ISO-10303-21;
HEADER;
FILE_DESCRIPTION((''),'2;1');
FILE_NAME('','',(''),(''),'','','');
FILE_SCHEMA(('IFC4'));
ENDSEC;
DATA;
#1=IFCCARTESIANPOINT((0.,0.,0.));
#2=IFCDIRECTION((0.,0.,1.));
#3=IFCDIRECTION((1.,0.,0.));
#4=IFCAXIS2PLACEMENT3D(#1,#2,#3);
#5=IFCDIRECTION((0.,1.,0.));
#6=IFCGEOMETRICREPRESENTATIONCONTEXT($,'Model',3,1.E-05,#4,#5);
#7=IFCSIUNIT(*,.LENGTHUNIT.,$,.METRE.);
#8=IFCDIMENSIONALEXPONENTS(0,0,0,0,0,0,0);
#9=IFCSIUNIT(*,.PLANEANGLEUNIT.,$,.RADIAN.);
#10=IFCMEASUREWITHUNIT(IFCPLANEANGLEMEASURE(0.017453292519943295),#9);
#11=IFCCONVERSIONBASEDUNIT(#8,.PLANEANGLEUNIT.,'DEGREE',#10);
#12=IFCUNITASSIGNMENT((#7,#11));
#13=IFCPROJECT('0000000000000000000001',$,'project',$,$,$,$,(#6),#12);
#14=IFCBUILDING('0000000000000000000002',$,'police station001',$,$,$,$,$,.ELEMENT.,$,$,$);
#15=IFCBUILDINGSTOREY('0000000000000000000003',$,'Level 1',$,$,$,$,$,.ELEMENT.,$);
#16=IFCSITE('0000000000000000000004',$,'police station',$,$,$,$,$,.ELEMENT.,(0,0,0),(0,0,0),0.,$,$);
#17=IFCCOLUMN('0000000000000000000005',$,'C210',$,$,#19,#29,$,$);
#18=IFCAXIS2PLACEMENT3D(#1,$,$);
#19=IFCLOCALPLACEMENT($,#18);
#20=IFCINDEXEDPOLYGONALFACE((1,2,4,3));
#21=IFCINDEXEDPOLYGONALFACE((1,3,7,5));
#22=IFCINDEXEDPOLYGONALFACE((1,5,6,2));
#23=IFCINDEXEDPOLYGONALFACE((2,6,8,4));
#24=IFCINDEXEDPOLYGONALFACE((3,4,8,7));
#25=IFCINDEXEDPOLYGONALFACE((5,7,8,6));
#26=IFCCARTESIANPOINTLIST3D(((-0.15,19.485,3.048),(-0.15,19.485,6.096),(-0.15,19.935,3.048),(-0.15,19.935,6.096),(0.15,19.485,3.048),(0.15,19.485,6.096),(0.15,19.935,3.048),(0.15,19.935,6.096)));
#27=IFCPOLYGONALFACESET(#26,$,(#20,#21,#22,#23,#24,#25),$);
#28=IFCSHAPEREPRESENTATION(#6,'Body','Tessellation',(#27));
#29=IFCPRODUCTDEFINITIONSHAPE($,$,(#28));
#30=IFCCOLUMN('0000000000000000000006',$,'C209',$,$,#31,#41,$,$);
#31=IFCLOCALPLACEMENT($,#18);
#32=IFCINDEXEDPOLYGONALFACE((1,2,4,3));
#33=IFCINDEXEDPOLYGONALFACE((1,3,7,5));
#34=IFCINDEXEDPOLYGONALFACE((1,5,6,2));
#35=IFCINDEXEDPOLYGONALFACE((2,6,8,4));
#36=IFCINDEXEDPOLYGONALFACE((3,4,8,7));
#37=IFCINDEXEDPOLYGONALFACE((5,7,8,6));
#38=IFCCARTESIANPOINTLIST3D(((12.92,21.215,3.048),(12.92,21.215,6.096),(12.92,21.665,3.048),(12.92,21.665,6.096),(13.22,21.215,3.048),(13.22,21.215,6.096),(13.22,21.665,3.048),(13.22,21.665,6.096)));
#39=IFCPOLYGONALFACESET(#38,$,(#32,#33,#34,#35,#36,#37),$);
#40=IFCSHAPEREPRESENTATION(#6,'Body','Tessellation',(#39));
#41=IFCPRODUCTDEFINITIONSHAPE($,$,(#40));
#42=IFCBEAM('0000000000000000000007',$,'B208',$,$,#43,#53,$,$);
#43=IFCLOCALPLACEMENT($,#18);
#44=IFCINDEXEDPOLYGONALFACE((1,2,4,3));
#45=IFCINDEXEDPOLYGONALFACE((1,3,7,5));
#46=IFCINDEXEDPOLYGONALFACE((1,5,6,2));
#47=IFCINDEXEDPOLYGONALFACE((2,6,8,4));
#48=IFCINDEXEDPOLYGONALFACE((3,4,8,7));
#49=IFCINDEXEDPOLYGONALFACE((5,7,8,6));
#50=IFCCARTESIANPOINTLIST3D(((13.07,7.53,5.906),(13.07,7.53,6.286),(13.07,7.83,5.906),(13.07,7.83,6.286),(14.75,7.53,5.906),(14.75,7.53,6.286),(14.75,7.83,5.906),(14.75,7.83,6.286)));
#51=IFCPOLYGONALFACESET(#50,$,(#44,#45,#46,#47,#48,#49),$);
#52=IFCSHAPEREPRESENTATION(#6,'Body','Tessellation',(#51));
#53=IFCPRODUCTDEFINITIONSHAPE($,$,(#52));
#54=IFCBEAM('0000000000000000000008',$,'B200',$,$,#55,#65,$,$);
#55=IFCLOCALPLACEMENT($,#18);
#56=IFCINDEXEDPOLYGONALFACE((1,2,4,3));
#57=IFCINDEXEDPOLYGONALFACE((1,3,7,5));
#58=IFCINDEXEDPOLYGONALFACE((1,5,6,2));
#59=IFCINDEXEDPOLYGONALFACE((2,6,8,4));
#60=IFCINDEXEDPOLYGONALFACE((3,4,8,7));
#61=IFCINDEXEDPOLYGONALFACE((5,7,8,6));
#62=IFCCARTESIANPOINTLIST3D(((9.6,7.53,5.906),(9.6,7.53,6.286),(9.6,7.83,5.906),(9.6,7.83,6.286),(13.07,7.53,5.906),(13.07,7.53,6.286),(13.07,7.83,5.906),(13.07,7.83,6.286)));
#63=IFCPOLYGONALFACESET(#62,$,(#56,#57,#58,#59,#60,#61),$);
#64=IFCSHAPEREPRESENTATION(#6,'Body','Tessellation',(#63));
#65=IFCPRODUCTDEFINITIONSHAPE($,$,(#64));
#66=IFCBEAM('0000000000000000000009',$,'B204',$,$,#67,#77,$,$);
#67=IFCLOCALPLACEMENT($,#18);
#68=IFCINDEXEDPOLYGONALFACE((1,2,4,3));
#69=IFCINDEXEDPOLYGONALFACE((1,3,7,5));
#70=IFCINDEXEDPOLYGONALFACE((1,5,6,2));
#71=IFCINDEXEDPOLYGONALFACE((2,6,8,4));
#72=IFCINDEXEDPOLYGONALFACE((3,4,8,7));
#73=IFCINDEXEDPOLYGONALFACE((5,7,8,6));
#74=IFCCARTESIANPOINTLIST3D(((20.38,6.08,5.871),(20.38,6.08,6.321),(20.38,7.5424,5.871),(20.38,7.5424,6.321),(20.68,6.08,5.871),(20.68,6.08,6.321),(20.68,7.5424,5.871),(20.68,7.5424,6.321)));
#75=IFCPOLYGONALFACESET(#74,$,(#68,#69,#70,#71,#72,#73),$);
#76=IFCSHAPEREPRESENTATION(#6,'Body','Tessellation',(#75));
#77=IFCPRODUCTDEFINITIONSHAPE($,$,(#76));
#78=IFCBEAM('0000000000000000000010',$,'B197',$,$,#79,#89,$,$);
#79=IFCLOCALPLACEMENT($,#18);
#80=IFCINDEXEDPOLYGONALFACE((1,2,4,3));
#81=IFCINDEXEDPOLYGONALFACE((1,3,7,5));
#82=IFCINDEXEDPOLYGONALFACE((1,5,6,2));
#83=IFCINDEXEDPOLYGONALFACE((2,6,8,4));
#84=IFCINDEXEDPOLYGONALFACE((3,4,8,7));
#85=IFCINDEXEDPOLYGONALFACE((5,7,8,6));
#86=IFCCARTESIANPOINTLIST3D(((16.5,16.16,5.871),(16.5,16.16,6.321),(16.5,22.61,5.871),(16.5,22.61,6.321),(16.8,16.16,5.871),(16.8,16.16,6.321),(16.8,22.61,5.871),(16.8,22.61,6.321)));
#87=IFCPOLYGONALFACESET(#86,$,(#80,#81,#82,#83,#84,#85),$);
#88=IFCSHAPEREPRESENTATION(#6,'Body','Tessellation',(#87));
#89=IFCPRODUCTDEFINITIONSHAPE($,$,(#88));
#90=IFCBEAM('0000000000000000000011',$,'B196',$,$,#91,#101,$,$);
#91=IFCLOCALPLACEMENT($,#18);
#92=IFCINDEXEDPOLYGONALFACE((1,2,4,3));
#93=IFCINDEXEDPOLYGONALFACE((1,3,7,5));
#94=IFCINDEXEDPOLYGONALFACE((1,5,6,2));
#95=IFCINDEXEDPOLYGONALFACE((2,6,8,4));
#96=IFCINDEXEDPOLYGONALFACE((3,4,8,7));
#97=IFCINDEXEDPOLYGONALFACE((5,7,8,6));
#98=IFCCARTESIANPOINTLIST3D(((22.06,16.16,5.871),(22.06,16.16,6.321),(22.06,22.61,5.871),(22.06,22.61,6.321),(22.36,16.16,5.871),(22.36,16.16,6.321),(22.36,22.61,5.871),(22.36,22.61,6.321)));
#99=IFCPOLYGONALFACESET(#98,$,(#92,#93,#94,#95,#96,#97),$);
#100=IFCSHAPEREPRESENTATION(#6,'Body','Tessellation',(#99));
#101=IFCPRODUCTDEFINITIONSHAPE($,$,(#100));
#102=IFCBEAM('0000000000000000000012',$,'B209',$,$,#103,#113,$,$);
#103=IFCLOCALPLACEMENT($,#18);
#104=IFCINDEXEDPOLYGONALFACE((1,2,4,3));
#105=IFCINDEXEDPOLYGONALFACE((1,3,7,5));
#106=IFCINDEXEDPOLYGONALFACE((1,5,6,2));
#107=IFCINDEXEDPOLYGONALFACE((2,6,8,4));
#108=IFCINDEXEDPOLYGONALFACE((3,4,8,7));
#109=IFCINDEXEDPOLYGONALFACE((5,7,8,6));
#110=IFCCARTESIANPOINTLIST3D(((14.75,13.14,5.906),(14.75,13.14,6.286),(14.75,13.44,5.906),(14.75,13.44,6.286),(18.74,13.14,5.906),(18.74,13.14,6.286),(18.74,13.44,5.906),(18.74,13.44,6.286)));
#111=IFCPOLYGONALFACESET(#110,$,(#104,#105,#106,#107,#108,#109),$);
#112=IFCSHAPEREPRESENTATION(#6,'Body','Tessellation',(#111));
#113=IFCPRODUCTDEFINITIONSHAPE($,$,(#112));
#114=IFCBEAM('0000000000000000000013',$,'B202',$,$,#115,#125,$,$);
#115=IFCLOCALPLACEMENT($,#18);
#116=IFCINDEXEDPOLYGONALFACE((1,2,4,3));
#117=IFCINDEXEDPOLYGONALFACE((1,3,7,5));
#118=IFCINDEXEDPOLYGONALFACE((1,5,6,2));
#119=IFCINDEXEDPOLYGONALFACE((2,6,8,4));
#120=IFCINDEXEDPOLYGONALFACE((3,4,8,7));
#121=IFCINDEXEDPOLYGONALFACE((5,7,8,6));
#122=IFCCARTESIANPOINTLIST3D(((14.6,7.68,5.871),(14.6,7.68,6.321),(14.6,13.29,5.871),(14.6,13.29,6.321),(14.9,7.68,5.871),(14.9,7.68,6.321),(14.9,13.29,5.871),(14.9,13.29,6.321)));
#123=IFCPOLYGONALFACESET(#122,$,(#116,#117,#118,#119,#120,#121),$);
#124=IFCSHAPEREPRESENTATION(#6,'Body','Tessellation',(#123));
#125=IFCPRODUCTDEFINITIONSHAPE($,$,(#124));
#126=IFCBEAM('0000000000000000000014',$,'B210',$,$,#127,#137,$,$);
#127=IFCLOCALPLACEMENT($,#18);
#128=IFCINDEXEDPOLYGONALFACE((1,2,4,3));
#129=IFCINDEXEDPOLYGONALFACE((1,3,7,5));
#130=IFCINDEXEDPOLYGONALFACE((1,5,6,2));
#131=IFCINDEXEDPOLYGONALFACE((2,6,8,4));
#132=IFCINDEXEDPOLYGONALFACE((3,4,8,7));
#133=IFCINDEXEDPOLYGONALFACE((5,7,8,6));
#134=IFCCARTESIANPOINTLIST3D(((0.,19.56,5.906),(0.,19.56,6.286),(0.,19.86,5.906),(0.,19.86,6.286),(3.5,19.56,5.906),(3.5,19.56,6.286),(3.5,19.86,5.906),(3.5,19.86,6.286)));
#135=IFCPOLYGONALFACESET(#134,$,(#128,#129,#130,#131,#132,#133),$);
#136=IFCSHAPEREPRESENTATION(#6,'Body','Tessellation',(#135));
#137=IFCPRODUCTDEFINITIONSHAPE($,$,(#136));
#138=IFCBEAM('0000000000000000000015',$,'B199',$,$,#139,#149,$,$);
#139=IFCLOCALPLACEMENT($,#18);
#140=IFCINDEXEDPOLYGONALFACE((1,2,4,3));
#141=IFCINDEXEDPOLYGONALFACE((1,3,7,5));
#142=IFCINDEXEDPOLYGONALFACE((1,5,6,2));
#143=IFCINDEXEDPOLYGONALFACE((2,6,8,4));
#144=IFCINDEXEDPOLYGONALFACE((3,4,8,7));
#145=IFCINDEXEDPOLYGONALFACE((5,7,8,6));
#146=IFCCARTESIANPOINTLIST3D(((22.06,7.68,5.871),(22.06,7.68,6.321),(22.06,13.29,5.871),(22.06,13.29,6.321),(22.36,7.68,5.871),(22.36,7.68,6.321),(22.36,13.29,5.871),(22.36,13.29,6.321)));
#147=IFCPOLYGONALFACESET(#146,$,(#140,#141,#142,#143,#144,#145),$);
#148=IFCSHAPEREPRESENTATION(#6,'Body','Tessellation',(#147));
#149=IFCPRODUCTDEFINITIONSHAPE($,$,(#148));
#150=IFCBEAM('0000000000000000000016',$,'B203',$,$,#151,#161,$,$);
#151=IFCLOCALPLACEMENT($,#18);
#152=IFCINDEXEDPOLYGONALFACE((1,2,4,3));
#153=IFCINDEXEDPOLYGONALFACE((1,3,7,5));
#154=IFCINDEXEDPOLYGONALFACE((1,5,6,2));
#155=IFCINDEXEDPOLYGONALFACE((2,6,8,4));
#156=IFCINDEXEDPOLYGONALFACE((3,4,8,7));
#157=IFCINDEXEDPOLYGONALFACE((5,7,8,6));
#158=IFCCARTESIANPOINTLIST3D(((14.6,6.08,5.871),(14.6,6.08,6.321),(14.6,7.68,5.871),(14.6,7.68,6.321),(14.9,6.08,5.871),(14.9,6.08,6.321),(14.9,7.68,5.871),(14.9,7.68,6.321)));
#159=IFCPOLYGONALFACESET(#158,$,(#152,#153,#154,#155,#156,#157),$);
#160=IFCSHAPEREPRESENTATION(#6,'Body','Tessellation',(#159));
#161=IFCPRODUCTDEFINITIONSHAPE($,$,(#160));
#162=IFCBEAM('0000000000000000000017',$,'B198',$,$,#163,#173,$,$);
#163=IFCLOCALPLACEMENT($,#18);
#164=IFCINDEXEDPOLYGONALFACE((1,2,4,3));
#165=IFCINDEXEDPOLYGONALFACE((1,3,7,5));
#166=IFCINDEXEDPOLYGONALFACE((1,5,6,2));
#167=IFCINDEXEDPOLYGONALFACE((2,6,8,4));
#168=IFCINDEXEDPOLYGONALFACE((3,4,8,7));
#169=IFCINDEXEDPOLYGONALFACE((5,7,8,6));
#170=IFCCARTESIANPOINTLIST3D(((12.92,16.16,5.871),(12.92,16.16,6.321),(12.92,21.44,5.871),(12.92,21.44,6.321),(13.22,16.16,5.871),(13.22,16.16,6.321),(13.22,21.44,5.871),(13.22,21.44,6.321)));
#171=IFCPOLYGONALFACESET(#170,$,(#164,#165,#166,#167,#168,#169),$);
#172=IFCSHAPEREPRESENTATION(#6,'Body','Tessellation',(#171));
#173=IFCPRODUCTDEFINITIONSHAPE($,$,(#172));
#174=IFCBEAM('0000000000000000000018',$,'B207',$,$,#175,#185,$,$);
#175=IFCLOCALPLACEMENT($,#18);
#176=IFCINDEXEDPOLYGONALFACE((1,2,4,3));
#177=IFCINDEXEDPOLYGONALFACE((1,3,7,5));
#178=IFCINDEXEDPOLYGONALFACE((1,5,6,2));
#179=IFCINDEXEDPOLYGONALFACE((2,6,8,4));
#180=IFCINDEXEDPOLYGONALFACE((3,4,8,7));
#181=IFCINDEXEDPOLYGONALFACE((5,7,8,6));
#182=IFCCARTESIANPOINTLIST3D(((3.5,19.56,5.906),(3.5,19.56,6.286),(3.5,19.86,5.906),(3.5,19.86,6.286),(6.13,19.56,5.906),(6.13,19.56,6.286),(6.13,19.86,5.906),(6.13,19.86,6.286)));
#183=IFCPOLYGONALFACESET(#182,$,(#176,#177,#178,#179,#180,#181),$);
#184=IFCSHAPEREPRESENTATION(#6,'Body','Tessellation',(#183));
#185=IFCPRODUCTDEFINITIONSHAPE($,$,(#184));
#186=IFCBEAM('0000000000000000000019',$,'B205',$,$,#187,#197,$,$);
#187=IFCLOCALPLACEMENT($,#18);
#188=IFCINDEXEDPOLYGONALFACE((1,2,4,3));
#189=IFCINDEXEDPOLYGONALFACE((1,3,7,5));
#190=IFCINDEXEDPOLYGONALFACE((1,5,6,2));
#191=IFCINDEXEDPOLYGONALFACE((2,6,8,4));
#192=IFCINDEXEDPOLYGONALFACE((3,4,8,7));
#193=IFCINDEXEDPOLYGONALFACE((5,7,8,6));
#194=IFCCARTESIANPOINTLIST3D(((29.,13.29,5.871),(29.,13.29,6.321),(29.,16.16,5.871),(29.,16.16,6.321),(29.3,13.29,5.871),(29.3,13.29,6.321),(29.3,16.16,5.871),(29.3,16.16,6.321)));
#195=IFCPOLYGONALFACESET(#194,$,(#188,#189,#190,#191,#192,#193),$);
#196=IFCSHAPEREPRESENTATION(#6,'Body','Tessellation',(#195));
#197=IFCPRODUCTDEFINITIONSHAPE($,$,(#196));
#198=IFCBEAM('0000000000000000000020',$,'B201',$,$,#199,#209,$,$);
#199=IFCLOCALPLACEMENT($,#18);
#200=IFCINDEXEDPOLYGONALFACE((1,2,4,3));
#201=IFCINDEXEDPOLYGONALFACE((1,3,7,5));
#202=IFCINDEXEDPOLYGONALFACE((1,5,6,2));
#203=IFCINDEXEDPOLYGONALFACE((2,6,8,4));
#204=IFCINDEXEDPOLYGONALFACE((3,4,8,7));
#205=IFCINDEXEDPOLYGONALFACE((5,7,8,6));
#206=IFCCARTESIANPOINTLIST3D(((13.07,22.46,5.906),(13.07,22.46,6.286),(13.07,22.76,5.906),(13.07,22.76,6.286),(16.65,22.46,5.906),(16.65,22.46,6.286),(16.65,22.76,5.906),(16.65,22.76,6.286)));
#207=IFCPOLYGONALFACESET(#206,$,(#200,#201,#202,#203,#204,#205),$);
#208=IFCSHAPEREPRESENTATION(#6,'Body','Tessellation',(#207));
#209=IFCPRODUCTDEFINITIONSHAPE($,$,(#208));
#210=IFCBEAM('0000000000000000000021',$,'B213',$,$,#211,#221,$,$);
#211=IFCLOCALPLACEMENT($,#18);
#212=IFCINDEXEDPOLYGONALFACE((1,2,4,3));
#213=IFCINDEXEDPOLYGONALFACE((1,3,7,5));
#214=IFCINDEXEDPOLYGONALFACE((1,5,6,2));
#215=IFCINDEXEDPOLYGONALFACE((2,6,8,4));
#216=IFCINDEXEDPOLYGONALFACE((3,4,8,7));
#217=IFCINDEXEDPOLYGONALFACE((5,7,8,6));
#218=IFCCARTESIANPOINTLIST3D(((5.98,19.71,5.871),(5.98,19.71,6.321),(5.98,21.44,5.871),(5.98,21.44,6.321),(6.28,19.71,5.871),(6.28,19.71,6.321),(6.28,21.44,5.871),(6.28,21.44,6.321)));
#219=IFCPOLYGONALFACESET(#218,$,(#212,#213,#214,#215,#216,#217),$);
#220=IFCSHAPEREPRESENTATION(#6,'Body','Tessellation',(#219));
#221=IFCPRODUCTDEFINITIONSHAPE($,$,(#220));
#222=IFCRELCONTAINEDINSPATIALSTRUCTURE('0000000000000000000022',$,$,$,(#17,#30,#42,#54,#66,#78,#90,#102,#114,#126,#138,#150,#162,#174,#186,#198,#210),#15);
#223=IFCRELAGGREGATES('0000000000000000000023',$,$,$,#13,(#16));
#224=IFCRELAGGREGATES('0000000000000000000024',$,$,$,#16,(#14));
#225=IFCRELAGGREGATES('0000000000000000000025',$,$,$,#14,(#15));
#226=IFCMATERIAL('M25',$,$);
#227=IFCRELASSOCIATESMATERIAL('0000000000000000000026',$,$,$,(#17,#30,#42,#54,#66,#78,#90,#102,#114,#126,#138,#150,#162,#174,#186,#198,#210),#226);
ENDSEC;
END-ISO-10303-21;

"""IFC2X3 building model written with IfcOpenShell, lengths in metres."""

from ifc_helpers import new_model, entity, si_unit, converted_unit, direction, frame, frame_2d, origin_with_axes, place, context, project, spatial, rectangle, extrude, material, element, save


model = new_model("IFC2X3")

# Units and contexts
model_context = context("Model", 3, precision=1e-05, world=origin_with_axes(), true_north=direction((0.0, 1.0, 0.0)))
ifc_project = project(units=[si_unit("LENGTHUNIT", "METRE"), converted_unit("PLANEANGLEUNIT", "DEGREE", entity("IfcPlaneAngleMeasure", 0.017453292519943295), si_unit("PLANEANGLEUNIT", "RADIAN"), dimensions=[0, 0, 0, 0, 0, 0, 0])], contexts=[model_context])

# Site, building, storey
site = spatial("IfcSite", under=ifc_project, Name="police station", CompositionType="ELEMENT", RefLatitude=(0, 0, 0), RefLongitude=(0, 0, 0), RefElevation=0.0)
building = spatial("IfcBuilding", under=site, Name="police station001", CompositionType="ELEMENT")
storey = spatial("IfcBuildingStorey", under=building, Name="Level 1", CompositionType="ELEMENT")

# Columns
ifc_material = material(Name="M25")
placement = place(None, origin_with_axes())
element("IfcColumn", 1, at=placement, inside=storey, material=ifc_material, Name="C210", context=model_context, shape_type="SweptSolid", body=[
    extrude(rectangle(XDim=0.3, YDim=0.45, at=frame_2d((0.0, 0.0), x_axis=(1.0, 0.0, 0.0))), frame((0.0, 19.71, 3.048), z_axis=(0.0, 0.0, 1.0), x_axis=(1.0, 0.0, 0.0)), (0.0, 0.0, 1.0), 3.048),
])
element("IfcColumn", 2, at=placement, inside=storey, material=ifc_material, Name="C209", context=model_context, shape_type="SweptSolid", body=[
    extrude(rectangle(XDim=0.3, YDim=0.45, at=frame_2d((0.0, 0.0), x_axis=(1.0, 0.0, 0.0))), frame((13.07, 21.44, 3.048), z_axis=(0.0, 0.0, 1.0), x_axis=(1.0, 0.0, 0.0)), (0.0, 0.0, 1.0), 3.048),
])

# Beams
element("IfcBeam", 3, at=placement, inside=storey, material=ifc_material, Name="B208", context=model_context, shape_type="SweptSolid", body=[
    extrude(rectangle(XDim=0.3, YDim=0.38, at=frame_2d((0.0, 0.0), x_axis=(0.0, 1.0, 0.0))), frame((13.07, 7.68, 6.096), z_axis=(1.0, 0.0, 0.0), x_axis=(0.0, 0.0, -1.0)), (0.0, 0.0, 1.0), 1.68),
])
element("IfcBeam", 4, at=placement, inside=storey, material=ifc_material, Name="B200", context=model_context, shape_type="SweptSolid", body=[
    extrude(rectangle(XDim=0.3, YDim=0.38, at=frame_2d((0.0, 0.0), x_axis=(0.0, 1.0, 0.0))), frame((9.6, 7.68, 6.096), z_axis=(1.0, 0.0, 0.0), x_axis=(0.0, 0.0, -1.0)), (0.0, 0.0, 1.0), 3.47),
])
element("IfcBeam", 5, at=placement, inside=storey, material=ifc_material, Name="B204", context=model_context, shape_type="SweptSolid", body=[
    extrude(rectangle(XDim=0.3, YDim=0.45, at=frame_2d((0.0, 0.0), x_axis=(0.0, 1.0, 0.0))), frame((20.53, 6.08, 6.096), z_axis=(0.0, 1.0, 0.0), x_axis=(0.0, 0.0, -1.0)), (0.0, 0.0, 1.0), 1.4624),
])
element("IfcBeam", 6, at=placement, inside=storey, material=ifc_material, Name="B197", context=model_context, shape_type="SweptSolid", body=[
    extrude(rectangle(XDim=0.3, YDim=0.45, at=frame_2d((0.0, 0.0), x_axis=(0.0, 1.0, 0.0))), frame((16.65, 16.16, 6.096), z_axis=(0.0, 1.0, 0.0), x_axis=(0.0, 0.0, -1.0)), (0.0, 0.0, 1.0), 6.45),
])
element("IfcBeam", 7, at=placement, inside=storey, material=ifc_material, Name="B196", context=model_context, shape_type="SweptSolid", body=[
    extrude(rectangle(XDim=0.3, YDim=0.45, at=frame_2d((0.0, 0.0), x_axis=(0.0, 1.0, 0.0))), frame((22.21, 16.16, 6.096), z_axis=(0.0, 1.0, 0.0), x_axis=(0.0, 0.0, -1.0)), (0.0, 0.0, 1.0), 6.45),
])
element("IfcBeam", 8, at=placement, inside=storey, material=ifc_material, Name="B209", context=model_context, shape_type="SweptSolid", body=[
    extrude(rectangle(XDim=0.3, YDim=0.38, at=frame_2d((0.0, 0.0), x_axis=(0.0, 1.0, 0.0))), frame((14.75, 13.29, 6.096), z_axis=(1.0, 0.0, 0.0), x_axis=(0.0, 0.0, -1.0)), (0.0, 0.0, 1.0), 3.99),
])
element("IfcBeam", 9, at=placement, inside=storey, material=ifc_material, Name="B202", context=model_context, shape_type="SweptSolid", body=[
    extrude(rectangle(XDim=0.3, YDim=0.45, at=frame_2d((0.0, 0.0), x_axis=(0.0, 1.0, 0.0))), frame((14.75, 7.68, 6.096), z_axis=(0.0, 1.0, 0.0), x_axis=(0.0, 0.0, -1.0)), (0.0, 0.0, 1.0), 5.61),
])
element("IfcBeam", 10, at=placement, inside=storey, material=ifc_material, Name="B210", context=model_context, shape_type="SweptSolid", body=[
    extrude(rectangle(XDim=0.3, YDim=0.38, at=frame_2d((0.0, 0.0), x_axis=(0.0, 1.0, 0.0))), frame((0.0, 19.71, 6.096), z_axis=(1.0, 0.0, 0.0), x_axis=(0.0, 0.0, -1.0)), (0.0, 0.0, 1.0), 3.5),
])
element("IfcBeam", 11, at=placement, inside=storey, material=ifc_material, Name="B199", context=model_context, shape_type="SweptSolid", body=[
    extrude(rectangle(XDim=0.3, YDim=0.45, at=frame_2d((0.0, 0.0), x_axis=(0.0, 1.0, 0.0))), frame((22.21, 7.68, 6.096), z_axis=(0.0, 1.0, 0.0), x_axis=(0.0, 0.0, -1.0)), (0.0, 0.0, 1.0), 5.61),
])
element("IfcBeam", 12, at=placement, inside=storey, material=ifc_material, Name="B203", context=model_context, shape_type="SweptSolid", body=[
    extrude(rectangle(XDim=0.3, YDim=0.45, at=frame_2d((0.0, 0.0), x_axis=(0.0, 1.0, 0.0))), frame((14.75, 6.08, 6.096), z_axis=(0.0, 1.0, 0.0), x_axis=(0.0, 0.0, -1.0)), (0.0, 0.0, 1.0), 1.6),
])
element("IfcBeam", 13, at=placement, inside=storey, material=ifc_material, Name="B198", context=model_context, shape_type="SweptSolid", body=[
    extrude(rectangle(XDim=0.3, YDim=0.45, at=frame_2d((0.0, 0.0), x_axis=(0.0, 1.0, 0.0))), frame((13.07, 16.16, 6.096), z_axis=(0.0, 1.0, 0.0), x_axis=(0.0, 0.0, -1.0)), (0.0, 0.0, 1.0), 5.28),
])
element("IfcBeam", 14, at=placement, inside=storey, material=ifc_material, Name="B207", context=model_context, shape_type="SweptSolid", body=[
    extrude(rectangle(XDim=0.3, YDim=0.38, at=frame_2d((0.0, 0.0), x_axis=(0.0, 1.0, 0.0))), frame((3.5, 19.71, 6.096), z_axis=(1.0, 0.0, 0.0), x_axis=(0.0, 0.0, -1.0)), (0.0, 0.0, 1.0), 2.63),
])
element("IfcBeam", 15, at=placement, inside=storey, material=ifc_material, Name="B205", context=model_context, shape_type="SweptSolid", body=[
    extrude(rectangle(XDim=0.3, YDim=0.45, at=frame_2d((0.0, 0.0), x_axis=(0.0, 1.0, 0.0))), frame((29.15, 13.29, 6.096), z_axis=(0.0, 1.0, 0.0), x_axis=(0.0, 0.0, -1.0)), (0.0, 0.0, 1.0), 2.87),
])
element("IfcBeam", 16, at=placement, inside=storey, material=ifc_material, Name="B201", context=model_context, shape_type="SweptSolid", body=[
    extrude(rectangle(XDim=0.3, YDim=0.38, at=frame_2d((0.0, 0.0), x_axis=(0.0, 1.0, 0.0))), frame((13.07, 22.61, 6.096), z_axis=(1.0, 0.0, 0.0), x_axis=(0.0, 0.0, -1.0)), (0.0, 0.0, 1.0), 3.58),
])
element("IfcBeam", 17, at=placement, inside=storey, material=ifc_material, Name="B213", context=model_context, shape_type="SweptSolid", body=[
    extrude(rectangle(XDim=0.3, YDim=0.45, at=frame_2d((0.0, 0.0), x_axis=(0.0, 1.0, 0.0))), frame((6.13, 19.71, 6.096), z_axis=(0.0, 1.0, 0.0), x_axis=(0.0, 0.0, -1.0)), (0.0, 0.0, 1.0), 1.73),
])

save(model, "model.ifc")
